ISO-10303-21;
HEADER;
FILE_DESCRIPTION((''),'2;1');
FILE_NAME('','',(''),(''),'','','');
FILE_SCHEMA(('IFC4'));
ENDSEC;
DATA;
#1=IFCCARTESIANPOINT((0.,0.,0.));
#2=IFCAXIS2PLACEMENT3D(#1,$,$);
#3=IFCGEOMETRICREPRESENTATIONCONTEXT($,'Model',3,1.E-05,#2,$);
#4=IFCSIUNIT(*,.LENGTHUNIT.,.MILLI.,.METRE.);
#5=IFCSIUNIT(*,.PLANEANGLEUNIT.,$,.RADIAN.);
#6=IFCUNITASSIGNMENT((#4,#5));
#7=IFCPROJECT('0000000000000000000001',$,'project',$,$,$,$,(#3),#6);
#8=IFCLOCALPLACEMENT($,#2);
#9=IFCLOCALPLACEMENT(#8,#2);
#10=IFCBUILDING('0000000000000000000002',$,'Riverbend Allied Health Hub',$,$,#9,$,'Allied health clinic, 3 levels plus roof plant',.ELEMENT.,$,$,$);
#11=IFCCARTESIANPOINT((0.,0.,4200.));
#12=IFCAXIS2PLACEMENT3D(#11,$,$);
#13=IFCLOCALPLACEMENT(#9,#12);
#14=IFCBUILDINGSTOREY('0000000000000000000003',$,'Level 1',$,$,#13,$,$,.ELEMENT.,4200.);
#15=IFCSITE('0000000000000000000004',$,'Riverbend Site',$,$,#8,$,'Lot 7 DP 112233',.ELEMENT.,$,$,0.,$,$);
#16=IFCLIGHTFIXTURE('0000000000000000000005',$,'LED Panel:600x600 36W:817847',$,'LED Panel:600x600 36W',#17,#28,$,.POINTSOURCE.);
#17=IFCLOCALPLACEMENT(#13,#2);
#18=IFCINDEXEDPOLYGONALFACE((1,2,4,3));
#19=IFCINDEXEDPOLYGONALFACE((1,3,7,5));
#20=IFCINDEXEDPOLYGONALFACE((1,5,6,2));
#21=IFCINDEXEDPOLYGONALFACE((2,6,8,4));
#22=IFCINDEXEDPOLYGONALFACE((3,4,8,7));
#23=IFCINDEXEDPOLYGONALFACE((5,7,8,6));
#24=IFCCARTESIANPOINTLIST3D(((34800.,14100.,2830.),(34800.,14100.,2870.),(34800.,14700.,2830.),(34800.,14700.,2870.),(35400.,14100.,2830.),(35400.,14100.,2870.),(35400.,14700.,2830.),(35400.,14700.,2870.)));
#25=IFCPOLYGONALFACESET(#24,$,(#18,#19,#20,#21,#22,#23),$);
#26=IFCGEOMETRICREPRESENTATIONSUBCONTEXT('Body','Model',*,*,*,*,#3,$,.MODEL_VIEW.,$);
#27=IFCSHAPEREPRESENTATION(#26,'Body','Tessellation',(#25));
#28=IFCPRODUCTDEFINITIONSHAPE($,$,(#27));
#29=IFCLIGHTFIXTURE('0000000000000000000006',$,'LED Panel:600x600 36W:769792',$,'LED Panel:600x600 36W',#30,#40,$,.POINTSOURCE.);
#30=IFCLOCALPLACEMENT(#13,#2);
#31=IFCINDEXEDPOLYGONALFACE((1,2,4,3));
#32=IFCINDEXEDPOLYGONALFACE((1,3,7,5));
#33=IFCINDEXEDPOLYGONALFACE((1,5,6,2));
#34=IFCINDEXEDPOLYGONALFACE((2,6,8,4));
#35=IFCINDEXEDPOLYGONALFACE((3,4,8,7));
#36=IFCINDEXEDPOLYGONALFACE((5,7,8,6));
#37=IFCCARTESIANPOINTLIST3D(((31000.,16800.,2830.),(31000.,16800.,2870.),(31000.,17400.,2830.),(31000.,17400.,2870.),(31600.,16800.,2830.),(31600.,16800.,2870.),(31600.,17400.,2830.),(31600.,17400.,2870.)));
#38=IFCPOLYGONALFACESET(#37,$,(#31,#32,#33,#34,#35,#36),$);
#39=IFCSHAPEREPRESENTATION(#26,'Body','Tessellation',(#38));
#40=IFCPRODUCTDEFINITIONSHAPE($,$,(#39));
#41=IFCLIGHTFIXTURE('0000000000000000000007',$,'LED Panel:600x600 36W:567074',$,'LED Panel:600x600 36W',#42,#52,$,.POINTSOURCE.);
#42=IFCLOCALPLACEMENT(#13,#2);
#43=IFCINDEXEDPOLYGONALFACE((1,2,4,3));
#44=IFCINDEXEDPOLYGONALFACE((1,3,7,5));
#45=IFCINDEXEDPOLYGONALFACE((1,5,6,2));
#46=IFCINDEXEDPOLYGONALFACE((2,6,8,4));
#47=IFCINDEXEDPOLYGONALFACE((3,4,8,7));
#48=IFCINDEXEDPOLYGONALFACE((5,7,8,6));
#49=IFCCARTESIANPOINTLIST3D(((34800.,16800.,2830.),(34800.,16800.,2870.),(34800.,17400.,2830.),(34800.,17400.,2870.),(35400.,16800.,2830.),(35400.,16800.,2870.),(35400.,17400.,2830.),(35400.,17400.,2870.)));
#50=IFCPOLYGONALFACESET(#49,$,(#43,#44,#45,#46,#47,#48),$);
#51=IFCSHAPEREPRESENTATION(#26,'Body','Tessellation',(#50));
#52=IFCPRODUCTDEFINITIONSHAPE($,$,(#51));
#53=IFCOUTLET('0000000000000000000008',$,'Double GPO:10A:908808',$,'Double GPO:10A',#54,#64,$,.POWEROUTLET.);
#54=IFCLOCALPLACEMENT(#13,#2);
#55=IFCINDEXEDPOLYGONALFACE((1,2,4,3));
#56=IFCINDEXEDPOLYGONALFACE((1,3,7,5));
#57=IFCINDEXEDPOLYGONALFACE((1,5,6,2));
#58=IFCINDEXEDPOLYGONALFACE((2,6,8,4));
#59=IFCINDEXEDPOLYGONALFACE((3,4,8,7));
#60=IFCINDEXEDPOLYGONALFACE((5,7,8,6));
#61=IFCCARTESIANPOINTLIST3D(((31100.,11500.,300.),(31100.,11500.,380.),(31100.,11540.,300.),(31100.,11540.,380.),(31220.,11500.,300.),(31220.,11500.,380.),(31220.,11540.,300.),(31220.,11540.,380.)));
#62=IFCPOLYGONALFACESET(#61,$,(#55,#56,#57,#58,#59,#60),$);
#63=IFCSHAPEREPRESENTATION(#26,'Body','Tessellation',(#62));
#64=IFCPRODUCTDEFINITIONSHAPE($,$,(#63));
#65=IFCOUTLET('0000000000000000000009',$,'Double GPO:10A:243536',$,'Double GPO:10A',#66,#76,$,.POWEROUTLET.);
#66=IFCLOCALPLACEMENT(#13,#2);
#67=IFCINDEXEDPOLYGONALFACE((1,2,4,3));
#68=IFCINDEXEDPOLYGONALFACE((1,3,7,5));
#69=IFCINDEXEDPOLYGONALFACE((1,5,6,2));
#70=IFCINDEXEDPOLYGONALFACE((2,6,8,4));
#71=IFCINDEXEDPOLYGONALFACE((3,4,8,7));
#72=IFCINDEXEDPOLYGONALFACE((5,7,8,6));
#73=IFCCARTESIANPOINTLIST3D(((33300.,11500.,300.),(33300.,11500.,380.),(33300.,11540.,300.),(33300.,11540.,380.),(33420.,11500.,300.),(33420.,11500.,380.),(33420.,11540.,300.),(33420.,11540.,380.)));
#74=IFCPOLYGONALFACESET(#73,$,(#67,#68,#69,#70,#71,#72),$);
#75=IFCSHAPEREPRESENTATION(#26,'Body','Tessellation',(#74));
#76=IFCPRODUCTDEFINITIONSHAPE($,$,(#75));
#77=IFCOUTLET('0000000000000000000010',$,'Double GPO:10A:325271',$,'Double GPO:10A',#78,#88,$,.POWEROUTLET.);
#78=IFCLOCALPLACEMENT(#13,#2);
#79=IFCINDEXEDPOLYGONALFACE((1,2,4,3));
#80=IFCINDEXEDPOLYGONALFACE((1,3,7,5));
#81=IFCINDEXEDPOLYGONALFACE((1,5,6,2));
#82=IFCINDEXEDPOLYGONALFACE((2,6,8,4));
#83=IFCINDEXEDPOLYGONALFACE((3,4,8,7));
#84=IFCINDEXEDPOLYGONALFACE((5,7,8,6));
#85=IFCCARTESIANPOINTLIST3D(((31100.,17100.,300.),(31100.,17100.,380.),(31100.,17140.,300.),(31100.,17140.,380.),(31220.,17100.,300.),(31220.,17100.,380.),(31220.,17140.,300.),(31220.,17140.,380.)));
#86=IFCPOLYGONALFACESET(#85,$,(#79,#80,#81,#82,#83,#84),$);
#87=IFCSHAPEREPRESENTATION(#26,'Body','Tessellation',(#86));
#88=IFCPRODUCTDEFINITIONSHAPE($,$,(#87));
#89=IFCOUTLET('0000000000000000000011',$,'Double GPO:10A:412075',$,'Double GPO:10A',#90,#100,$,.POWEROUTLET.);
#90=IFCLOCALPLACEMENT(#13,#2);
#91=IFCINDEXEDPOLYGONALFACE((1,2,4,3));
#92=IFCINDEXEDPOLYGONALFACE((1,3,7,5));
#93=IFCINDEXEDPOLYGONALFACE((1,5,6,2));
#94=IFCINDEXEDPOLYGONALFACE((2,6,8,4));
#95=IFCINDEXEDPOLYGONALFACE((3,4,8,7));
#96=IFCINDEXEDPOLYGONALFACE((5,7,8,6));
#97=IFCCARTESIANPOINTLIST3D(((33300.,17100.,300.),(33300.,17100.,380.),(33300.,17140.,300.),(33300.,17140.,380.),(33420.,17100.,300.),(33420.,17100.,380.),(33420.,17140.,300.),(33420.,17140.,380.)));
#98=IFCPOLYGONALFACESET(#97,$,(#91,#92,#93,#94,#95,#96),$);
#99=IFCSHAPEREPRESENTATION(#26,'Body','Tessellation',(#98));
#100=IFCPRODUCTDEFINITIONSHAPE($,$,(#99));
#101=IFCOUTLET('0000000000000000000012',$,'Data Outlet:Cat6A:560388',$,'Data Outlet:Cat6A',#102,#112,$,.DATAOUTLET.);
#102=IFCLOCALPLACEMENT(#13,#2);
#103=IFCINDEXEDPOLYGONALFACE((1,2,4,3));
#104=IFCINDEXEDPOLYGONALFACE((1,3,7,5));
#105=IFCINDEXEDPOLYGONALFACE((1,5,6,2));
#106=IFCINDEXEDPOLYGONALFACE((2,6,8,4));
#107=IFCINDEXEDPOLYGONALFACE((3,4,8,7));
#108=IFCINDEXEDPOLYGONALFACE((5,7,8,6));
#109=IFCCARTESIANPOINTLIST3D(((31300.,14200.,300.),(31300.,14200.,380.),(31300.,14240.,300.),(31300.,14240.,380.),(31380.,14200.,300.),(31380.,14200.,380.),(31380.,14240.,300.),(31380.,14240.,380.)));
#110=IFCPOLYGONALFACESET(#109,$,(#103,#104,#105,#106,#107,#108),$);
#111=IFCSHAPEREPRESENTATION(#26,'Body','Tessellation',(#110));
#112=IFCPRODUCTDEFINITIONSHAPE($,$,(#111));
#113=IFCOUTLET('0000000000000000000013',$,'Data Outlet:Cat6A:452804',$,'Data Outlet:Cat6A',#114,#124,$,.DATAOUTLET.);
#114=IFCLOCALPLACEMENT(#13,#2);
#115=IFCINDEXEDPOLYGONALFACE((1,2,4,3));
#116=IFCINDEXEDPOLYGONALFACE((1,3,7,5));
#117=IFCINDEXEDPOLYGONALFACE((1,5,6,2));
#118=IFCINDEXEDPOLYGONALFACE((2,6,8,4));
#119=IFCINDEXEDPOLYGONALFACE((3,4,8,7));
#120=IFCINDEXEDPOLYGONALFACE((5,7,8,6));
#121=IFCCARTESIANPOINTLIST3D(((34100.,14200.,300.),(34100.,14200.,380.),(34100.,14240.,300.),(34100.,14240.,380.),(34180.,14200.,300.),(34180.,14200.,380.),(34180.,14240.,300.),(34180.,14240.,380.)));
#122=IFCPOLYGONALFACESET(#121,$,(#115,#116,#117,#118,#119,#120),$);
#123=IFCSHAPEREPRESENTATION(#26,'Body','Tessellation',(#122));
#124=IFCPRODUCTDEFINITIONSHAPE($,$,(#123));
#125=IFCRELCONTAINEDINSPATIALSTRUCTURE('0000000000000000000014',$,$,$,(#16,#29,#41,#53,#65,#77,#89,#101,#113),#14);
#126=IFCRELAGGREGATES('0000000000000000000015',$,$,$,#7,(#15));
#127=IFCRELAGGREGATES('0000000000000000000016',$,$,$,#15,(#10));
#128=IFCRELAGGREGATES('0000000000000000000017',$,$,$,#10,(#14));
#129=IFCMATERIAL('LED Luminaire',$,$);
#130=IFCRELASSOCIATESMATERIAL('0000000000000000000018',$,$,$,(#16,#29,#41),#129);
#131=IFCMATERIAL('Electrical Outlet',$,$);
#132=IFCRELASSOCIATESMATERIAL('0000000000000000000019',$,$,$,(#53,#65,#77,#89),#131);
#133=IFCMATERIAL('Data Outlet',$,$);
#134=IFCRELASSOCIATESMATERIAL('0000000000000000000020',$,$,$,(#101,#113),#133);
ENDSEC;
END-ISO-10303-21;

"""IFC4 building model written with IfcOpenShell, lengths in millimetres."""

from ifc_helpers import new_model, si_unit, frame, frame_2d, origin, place, context, subcontext, project, spatial, rectangle, extrude, material, element, save


model = new_model("IFC4")

# Units and contexts
model_context = context("Model", 3, precision=1e-05, world=origin())
body_context = subcontext(model_context, "Body", "Model", "MODEL_VIEW")
ifc_project = project(units=[si_unit("LENGTHUNIT", "METRE", prefix="MILLI"), si_unit("PLANEANGLEUNIT", "RADIAN")], contexts=[model_context])

# Site, building, storey
site_placement = place(None, origin())
site = spatial("IfcSite", under=ifc_project, at=site_placement, Name="Riverbend Site", LongName="Lot 7 DP 112233", CompositionType="ELEMENT", RefElevation=0.0)
building_placement = place(site_placement, origin())
building = spatial("IfcBuilding", under=site, at=building_placement, Name="Riverbend Allied Health Hub", LongName="Allied health clinic, 3 levels plus roof plant", CompositionType="ELEMENT")
storey_placement = place(building_placement, frame((0.0, 0.0, 4200.0)))
storey = spatial("IfcBuildingStorey", under=building, at=storey_placement, Name="Level 1", CompositionType="ELEMENT", Elevation=4200.0)

# Light fixtures
ifc_material_1 = material(Name="LED Luminaire")
for number, where, name in (
    (1, (34800.0, 14100.0, 2830.0), "LED Panel:600x600 36W:817847"),
    (2, (31000.0, 16800.0, 2830.0), "LED Panel:600x600 36W:769792"),
    (3, (34800.0, 16800.0, 2830.0), "LED Panel:600x600 36W:567074"),
):
    element("IfcLightFixture", number, at=place(storey_placement, frame(where)), inside=storey, material=ifc_material_1, Name=name, ObjectType="LED Panel:600x600 36W", PredefinedType="POINTSOURCE", context=body_context, shape_type="SweptSolid", body=[
        extrude(rectangle(XDim=600.0, YDim=600.0, at=frame_2d((300.0, 300.0))), origin(), (0.0, 0.0, 1.0), 40.0),
    ])

# Outlets
ifc_material_2 = material(Name="Electrical Outlet")
for number, where, name in (
    (4, (31100.0, 11500.0, 300.0), "Double GPO:10A:908808"),
    (5, (33300.0, 11500.0, 300.0), "Double GPO:10A:243536"),
    (6, (31100.0, 17100.0, 300.0), "Double GPO:10A:325271"),
    (7, (33300.0, 17100.0, 300.0), "Double GPO:10A:412075"),
):
    element("IfcOutlet", number, at=place(storey_placement, frame(where)), inside=storey, material=ifc_material_2, Name=name, ObjectType="Double GPO:10A", PredefinedType="POWEROUTLET", context=body_context, shape_type="SweptSolid", body=[
        extrude(rectangle(XDim=120.0, YDim=40.0, at=frame_2d((60.0, 20.0))), origin(), (0.0, 0.0, 1.0), 80.0),
    ])
ifc_material_3 = material(Name="Data Outlet")
for number, where, name in (
    (8, (31300.0, 14200.0, 300.0), "Data Outlet:Cat6A:560388"),
    (9, (34100.0, 14200.0, 300.0), "Data Outlet:Cat6A:452804"),
):
    element("IfcOutlet", number, at=place(storey_placement, frame(where)), inside=storey, material=ifc_material_3, Name=name, ObjectType="Data Outlet:Cat6A", PredefinedType="DATAOUTLET", context=body_context, shape_type="SweptSolid", body=[
        extrude(rectangle(XDim=80.0, YDim=40.0, at=frame_2d((40.0, 20.0))), origin(), (0.0, 0.0, 1.0), 80.0),
    ])

save(model, "model.ifc")
